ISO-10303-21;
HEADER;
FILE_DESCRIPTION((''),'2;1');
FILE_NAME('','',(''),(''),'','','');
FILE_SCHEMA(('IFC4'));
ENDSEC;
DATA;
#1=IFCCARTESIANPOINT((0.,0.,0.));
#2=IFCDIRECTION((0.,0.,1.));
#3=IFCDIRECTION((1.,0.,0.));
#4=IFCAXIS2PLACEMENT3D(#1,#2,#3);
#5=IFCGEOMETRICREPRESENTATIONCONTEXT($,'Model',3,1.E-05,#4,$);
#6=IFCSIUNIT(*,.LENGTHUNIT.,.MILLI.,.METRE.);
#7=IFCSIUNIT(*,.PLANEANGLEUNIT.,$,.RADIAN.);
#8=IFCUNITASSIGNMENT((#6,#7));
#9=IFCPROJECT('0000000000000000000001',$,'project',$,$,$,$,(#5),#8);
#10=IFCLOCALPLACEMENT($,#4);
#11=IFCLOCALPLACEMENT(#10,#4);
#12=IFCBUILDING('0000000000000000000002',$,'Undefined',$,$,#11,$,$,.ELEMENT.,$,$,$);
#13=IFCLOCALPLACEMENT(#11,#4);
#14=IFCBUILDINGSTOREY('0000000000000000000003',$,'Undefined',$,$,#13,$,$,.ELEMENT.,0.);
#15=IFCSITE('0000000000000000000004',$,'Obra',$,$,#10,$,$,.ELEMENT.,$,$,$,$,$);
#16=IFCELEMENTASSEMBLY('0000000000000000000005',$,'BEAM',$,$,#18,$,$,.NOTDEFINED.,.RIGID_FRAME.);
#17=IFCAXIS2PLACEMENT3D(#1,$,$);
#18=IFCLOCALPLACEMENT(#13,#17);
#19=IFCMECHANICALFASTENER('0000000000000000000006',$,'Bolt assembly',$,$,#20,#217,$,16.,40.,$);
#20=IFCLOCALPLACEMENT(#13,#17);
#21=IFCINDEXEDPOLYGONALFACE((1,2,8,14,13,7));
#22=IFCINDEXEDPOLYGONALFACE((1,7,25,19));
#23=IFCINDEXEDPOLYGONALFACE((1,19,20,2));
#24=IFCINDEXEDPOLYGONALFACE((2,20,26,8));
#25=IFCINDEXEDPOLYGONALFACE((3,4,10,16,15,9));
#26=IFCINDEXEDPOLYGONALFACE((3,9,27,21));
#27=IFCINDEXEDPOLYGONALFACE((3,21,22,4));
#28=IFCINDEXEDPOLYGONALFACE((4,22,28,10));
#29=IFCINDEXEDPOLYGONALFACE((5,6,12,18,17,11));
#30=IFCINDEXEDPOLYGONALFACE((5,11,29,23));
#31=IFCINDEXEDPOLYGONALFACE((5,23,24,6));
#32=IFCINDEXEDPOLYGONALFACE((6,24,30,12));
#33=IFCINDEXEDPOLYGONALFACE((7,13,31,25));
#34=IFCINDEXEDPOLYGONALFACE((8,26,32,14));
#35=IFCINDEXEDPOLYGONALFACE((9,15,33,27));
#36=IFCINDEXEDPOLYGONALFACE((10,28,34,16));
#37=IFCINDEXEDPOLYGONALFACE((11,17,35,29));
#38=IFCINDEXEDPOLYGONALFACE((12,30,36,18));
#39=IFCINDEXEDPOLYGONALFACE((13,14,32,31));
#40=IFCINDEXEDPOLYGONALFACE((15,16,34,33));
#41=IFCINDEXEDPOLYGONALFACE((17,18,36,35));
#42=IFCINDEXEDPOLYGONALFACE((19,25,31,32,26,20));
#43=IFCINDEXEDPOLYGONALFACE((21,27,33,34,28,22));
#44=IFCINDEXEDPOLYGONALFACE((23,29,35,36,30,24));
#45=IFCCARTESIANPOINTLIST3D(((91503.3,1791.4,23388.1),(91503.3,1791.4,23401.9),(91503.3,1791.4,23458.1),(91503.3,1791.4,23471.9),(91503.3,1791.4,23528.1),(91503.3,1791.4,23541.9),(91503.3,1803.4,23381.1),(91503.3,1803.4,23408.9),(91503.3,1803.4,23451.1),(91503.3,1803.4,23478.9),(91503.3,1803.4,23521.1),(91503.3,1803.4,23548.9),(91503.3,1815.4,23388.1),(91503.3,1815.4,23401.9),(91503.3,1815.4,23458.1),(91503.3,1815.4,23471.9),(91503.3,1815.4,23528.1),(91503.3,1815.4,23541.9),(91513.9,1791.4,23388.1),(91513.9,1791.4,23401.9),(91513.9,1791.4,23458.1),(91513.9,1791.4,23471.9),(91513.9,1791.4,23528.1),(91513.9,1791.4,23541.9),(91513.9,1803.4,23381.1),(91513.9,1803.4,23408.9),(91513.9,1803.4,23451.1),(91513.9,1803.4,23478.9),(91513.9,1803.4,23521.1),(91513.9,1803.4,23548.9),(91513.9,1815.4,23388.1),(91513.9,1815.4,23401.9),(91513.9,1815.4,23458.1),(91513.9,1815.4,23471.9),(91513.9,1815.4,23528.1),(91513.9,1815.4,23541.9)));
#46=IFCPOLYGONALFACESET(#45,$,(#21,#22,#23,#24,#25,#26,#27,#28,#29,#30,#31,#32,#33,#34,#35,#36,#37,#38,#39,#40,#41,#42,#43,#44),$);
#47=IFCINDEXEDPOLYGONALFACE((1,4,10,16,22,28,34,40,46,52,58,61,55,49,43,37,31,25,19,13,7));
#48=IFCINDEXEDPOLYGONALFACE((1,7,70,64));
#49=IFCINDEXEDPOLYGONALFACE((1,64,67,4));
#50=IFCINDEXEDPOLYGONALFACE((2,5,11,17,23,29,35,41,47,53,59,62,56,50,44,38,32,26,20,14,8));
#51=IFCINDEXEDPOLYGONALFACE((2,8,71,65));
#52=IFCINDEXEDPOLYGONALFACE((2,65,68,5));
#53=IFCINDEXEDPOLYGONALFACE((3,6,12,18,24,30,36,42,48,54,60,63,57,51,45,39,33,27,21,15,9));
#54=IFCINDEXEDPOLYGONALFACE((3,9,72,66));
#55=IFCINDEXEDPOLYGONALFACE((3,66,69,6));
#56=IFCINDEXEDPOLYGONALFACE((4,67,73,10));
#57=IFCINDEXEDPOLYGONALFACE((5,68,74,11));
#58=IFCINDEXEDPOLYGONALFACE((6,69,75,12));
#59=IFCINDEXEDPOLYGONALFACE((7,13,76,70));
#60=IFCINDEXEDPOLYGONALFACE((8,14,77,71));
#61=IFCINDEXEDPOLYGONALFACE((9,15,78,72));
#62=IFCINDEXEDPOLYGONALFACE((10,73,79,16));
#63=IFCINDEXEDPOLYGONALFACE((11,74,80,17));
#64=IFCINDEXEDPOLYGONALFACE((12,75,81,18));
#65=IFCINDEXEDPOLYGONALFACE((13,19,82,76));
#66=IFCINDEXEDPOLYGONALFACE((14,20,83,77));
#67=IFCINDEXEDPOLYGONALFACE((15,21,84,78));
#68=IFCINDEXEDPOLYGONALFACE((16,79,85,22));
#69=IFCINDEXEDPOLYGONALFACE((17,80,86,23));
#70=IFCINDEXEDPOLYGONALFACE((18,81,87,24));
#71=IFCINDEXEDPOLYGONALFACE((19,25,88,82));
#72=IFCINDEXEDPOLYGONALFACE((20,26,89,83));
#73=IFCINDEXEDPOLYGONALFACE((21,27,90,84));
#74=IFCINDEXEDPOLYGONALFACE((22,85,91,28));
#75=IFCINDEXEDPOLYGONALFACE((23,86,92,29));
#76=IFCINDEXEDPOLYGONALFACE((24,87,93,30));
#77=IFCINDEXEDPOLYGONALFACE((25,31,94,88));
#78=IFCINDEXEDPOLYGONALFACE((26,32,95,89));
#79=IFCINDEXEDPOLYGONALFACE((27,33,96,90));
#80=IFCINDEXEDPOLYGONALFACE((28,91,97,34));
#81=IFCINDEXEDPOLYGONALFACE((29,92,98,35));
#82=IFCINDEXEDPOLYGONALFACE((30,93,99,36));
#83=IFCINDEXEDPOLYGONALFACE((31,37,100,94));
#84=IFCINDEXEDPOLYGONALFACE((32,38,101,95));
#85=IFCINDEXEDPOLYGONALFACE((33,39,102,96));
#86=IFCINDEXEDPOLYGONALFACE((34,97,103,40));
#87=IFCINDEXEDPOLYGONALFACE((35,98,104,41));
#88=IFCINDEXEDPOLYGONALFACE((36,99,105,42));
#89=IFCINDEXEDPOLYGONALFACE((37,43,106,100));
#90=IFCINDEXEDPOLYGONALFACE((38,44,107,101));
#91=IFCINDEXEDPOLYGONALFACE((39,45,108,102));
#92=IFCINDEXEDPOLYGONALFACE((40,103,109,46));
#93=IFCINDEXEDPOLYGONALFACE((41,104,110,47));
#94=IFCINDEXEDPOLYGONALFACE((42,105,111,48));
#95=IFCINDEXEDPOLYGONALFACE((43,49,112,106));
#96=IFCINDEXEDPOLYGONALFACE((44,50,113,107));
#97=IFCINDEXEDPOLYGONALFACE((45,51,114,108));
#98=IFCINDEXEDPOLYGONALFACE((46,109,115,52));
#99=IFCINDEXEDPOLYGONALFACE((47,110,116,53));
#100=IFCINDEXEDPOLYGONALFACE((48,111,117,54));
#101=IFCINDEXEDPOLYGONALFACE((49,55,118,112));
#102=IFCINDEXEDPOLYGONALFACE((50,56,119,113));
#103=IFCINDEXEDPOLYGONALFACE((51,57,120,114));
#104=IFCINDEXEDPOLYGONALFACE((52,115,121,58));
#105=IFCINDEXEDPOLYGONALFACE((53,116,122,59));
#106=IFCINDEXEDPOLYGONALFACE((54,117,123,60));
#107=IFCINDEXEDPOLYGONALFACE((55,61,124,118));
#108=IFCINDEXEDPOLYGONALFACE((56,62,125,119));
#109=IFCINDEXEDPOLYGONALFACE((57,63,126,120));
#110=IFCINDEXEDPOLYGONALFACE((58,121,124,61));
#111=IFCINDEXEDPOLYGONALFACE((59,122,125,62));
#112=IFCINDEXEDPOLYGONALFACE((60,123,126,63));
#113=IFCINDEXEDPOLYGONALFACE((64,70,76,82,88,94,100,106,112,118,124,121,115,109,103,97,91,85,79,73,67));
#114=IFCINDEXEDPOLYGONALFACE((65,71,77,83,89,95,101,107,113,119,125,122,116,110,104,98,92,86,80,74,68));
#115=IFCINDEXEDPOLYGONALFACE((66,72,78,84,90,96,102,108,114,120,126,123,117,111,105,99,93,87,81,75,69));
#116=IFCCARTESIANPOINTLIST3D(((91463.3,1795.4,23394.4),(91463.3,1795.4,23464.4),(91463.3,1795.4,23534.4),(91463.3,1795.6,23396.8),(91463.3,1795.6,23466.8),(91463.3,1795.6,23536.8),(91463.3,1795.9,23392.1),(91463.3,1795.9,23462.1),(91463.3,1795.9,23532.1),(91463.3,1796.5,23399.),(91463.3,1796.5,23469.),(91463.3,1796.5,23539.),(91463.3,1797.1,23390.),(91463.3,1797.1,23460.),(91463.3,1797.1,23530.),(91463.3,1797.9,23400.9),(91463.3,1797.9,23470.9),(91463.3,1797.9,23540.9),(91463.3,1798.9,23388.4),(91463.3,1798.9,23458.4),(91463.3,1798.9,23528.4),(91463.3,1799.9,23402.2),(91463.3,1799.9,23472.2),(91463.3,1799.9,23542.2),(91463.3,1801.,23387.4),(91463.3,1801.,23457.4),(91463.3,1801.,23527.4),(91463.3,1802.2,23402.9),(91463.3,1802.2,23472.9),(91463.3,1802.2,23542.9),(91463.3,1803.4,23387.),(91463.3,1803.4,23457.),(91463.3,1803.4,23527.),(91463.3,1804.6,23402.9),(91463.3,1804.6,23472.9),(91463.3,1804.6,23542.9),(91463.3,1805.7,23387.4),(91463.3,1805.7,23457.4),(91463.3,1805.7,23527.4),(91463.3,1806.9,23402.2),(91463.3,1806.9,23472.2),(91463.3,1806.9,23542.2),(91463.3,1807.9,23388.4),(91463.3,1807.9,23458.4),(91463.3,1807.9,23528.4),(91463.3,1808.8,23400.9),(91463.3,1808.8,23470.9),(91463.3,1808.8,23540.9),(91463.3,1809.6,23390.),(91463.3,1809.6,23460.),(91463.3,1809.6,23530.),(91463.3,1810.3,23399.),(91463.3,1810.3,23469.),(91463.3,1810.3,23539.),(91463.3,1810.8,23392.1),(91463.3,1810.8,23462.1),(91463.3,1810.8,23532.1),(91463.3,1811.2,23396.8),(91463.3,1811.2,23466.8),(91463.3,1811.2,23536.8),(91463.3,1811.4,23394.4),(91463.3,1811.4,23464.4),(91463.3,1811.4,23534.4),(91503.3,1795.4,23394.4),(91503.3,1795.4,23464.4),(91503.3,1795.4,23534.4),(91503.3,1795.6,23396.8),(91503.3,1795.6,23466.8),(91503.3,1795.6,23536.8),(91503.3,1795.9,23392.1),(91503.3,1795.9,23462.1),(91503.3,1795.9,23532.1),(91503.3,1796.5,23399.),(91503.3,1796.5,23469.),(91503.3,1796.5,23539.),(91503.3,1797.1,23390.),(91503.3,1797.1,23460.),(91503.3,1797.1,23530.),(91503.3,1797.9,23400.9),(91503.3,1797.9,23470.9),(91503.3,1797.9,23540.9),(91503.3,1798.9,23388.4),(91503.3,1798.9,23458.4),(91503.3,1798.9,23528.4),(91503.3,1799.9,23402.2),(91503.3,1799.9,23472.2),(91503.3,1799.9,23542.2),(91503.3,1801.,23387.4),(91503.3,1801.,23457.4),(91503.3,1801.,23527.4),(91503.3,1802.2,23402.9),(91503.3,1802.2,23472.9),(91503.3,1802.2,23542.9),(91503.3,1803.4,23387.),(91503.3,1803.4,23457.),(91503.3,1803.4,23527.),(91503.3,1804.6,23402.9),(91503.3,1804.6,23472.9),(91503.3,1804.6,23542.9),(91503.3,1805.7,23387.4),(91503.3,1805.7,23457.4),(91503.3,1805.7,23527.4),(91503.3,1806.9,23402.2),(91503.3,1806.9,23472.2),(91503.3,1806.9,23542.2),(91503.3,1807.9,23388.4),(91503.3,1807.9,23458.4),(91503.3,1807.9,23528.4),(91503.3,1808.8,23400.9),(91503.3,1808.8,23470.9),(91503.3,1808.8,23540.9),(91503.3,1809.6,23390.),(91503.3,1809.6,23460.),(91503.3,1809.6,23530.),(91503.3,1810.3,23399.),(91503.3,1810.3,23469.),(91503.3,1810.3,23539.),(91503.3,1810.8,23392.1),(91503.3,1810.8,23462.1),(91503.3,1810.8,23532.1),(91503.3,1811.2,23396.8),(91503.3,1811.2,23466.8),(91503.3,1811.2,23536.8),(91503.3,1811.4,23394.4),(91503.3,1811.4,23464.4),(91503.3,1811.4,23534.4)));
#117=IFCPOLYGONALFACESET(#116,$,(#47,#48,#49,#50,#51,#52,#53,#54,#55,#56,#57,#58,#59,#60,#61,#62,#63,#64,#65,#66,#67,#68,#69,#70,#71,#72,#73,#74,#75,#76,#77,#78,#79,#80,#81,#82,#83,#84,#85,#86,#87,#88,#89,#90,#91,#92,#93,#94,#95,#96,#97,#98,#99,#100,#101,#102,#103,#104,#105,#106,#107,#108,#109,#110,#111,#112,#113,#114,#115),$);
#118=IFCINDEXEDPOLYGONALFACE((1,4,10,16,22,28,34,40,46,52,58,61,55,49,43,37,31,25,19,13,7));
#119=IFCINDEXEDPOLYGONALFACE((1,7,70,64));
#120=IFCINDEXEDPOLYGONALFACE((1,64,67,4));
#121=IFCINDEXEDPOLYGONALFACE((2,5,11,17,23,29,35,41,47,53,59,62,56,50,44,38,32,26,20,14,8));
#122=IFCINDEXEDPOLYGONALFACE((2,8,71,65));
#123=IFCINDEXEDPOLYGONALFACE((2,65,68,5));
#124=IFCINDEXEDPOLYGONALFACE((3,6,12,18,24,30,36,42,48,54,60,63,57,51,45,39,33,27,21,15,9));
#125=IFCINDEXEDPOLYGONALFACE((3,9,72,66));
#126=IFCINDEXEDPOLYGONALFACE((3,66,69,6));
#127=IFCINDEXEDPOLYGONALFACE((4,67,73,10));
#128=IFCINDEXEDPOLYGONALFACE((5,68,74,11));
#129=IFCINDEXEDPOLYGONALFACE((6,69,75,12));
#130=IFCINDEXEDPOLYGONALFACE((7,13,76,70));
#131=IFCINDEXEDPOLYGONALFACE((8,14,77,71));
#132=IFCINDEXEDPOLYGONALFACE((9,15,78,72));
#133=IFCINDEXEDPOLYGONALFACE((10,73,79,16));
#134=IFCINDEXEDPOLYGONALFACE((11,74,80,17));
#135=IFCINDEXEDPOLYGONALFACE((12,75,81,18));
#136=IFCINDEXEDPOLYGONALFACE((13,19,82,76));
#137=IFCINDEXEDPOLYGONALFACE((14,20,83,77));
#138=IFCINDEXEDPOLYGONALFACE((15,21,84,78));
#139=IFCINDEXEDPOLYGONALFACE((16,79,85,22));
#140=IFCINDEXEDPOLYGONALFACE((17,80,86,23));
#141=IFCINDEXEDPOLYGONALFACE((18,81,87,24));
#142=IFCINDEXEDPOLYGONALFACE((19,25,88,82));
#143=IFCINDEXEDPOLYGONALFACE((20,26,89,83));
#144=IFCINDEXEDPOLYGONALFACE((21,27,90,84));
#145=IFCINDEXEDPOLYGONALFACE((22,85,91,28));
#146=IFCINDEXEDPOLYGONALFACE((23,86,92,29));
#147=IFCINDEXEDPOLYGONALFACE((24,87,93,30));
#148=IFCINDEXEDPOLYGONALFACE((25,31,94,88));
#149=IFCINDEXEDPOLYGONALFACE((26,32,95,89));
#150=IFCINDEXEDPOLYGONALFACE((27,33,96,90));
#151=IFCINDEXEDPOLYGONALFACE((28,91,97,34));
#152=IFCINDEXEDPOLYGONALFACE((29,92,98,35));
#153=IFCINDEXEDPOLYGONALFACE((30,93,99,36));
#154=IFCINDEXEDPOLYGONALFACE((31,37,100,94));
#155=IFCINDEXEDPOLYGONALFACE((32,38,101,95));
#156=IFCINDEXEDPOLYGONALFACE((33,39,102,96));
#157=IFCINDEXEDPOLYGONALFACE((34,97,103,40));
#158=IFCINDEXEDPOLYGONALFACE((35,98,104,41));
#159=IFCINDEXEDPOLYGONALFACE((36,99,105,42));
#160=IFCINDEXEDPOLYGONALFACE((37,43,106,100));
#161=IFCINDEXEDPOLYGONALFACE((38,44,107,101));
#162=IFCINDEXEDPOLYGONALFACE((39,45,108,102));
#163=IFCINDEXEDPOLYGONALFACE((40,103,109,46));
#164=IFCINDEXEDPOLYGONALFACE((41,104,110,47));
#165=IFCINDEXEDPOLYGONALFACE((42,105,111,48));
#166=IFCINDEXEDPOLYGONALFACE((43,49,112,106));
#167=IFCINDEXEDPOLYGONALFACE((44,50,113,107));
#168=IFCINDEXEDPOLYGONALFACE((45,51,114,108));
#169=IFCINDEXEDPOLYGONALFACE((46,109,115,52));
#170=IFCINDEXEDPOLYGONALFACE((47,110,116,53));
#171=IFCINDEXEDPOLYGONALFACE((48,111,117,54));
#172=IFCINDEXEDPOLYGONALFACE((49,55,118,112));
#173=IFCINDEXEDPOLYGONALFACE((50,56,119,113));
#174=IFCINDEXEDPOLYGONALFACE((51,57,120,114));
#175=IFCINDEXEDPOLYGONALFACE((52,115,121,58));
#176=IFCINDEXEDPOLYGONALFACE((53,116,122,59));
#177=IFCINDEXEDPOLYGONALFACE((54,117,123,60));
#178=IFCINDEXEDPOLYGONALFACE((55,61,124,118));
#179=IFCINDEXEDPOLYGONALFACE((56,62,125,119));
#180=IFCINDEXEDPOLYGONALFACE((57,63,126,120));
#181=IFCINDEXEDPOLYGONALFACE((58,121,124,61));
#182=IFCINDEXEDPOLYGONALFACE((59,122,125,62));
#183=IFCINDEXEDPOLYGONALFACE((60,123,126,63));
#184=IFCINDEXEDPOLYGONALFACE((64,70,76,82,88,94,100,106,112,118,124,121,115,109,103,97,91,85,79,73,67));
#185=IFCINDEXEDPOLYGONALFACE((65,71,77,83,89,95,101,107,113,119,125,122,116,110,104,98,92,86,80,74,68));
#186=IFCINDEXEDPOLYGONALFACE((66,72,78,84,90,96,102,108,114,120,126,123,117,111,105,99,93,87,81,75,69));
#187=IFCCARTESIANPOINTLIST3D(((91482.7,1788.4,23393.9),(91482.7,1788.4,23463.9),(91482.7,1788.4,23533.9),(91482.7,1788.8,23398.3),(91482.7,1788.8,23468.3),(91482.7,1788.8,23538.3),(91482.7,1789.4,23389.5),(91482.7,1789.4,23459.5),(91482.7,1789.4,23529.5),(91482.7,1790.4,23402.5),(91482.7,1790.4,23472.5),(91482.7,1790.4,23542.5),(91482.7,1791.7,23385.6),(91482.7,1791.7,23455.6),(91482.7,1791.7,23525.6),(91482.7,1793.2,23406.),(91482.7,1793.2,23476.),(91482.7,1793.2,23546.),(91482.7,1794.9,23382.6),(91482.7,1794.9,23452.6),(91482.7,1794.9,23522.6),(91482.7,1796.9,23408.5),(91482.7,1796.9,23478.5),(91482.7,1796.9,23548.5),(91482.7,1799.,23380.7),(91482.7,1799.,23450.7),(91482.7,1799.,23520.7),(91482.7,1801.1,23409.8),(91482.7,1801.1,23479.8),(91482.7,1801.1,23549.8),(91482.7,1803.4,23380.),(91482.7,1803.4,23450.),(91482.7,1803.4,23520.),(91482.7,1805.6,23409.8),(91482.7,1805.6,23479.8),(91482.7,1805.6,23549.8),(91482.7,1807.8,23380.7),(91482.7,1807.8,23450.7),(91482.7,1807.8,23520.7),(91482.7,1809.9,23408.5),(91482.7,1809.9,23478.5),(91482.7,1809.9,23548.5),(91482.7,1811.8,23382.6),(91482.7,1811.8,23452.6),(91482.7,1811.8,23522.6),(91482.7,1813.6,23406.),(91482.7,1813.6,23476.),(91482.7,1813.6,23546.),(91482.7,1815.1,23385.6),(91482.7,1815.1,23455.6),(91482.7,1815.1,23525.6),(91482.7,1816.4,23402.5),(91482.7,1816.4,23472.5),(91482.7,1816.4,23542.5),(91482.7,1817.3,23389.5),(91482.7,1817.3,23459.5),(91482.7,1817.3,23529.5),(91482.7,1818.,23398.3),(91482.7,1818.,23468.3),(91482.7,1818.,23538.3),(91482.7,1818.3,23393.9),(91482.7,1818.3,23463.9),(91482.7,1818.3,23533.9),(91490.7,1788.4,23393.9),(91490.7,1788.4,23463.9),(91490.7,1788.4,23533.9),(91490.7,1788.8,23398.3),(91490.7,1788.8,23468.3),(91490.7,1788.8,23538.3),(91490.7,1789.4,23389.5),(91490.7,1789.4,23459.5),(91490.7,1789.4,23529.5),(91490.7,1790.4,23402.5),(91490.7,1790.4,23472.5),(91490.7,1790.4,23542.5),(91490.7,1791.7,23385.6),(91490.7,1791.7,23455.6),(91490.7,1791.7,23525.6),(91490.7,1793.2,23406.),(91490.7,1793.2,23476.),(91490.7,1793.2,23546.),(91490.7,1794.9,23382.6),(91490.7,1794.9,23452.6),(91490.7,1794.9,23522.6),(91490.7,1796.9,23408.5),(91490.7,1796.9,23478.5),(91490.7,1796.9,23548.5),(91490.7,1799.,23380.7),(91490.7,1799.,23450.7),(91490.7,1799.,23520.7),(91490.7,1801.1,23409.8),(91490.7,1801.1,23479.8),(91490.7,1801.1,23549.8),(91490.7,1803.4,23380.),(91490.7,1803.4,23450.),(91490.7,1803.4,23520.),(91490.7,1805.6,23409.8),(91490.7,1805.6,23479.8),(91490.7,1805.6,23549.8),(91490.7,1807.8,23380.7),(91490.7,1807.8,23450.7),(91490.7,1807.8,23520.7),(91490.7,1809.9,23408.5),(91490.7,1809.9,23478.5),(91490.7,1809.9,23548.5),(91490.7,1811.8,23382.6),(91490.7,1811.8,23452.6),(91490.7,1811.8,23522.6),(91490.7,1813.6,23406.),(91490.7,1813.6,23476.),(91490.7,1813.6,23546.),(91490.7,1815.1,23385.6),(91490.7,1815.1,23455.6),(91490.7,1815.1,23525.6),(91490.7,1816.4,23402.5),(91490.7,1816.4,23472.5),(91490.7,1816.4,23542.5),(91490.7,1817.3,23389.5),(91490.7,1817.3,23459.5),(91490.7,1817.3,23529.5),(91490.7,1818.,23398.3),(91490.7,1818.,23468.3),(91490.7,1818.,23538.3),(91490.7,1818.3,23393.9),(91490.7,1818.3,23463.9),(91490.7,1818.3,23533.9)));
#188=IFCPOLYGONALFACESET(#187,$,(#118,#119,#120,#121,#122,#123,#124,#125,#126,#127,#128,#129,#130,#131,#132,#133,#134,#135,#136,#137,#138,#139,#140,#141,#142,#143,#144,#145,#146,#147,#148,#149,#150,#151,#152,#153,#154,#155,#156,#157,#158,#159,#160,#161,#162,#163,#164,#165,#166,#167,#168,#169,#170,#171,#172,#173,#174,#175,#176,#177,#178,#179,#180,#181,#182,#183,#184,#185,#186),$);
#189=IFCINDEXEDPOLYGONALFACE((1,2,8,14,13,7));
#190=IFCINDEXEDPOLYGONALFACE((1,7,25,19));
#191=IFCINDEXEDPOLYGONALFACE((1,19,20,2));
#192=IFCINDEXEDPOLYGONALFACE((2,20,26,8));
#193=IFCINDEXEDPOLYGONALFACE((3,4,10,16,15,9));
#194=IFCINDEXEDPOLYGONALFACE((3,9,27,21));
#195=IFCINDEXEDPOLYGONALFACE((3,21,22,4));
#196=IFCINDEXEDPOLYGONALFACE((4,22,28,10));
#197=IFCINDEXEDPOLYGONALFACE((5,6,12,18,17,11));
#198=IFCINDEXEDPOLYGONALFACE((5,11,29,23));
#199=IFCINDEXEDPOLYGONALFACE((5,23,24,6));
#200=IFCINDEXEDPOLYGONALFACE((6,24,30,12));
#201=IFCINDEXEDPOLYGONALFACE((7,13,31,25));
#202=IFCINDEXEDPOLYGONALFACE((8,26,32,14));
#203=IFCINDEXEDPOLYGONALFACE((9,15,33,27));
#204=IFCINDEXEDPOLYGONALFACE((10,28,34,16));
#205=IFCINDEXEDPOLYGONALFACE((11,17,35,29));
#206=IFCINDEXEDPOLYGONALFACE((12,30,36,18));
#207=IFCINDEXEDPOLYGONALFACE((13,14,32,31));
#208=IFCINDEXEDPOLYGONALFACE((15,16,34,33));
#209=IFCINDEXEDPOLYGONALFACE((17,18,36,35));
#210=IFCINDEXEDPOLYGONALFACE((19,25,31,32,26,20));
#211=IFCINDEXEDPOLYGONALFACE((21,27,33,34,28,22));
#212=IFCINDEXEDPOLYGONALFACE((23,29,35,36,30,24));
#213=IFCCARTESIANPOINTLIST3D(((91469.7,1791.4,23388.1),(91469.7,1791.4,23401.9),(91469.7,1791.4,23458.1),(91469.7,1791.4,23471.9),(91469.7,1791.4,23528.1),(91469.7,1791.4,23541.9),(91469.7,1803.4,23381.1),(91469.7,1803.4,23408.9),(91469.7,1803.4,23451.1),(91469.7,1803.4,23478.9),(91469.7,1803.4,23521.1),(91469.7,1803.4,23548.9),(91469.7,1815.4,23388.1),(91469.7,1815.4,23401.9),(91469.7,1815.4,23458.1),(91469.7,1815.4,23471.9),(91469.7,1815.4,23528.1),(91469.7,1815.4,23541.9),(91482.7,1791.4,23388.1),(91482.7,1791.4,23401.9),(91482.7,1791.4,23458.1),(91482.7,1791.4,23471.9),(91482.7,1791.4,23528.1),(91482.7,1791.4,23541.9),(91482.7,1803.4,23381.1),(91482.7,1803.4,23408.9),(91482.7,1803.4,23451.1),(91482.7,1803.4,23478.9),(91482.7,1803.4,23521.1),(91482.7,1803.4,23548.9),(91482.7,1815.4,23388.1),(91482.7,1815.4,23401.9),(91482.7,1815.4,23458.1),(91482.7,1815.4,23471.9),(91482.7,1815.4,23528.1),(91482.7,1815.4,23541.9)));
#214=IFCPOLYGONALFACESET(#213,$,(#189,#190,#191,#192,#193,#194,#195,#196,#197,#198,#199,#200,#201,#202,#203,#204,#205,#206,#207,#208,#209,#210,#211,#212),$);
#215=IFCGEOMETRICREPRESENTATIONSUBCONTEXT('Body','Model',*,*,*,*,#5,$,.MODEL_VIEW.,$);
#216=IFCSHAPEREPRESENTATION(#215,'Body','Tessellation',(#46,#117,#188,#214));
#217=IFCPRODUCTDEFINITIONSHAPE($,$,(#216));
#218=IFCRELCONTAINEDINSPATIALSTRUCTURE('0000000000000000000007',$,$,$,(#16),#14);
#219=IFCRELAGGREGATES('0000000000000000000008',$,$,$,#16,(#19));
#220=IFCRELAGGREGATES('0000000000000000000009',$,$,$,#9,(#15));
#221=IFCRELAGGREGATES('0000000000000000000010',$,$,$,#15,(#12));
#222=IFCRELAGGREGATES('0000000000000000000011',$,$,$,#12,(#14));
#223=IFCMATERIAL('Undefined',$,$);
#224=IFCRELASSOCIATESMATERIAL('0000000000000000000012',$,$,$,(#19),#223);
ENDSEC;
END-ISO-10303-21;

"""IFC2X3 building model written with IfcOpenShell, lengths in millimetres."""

from ifc_helpers import new_model, si_unit, frame, origin_with_axes, origin_2d_with_axis, place, context, subcontext, project, spatial, polyline, circle, outline, extrude, source, transform, mapped, material, element, aggregate, save


model = new_model("IFC2X3")

# Units and contexts
model_context = context("Model", 3, precision=1e-05, world=origin_with_axes())
body_context = subcontext(model_context, "Body", "Model", "MODEL_VIEW")
ifc_project = project(units=[si_unit("LENGTHUNIT", "METRE", prefix="MILLI"), si_unit("PLANEANGLEUNIT", "RADIAN")], contexts=[model_context])

# Site, building, storey
site_placement = place(None, origin_with_axes())
site = spatial("IfcSite", under=ifc_project, at=site_placement, Name="Obra", CompositionType="ELEMENT")
building_placement = place(site_placement, origin_with_axes())
building = spatial("IfcBuilding", under=site, at=building_placement, Name="Undefined", CompositionType="ELEMENT")
storey_placement = place(building_placement, origin_with_axes())
storey = spatial("IfcBuildingStorey", under=building, at=storey_placement, Name="Undefined", CompositionType="ELEMENT", Elevation=0.0)

# Element assembly
assembly_1_placement = place(storey_placement, origin_with_axes())
assembly_1 = element("IfcElementAssembly", 1, at=assembly_1_placement, inside=storey, Name="BEAM", AssemblyPlace="NOTDEFINED", PredefinedType="RIGID_FRAME")

# Mechanical fastener
ifc_material_1 = material(Name="Undefined")
shared_shape_1 = source(origin_with_axes(), body_context, "Body", "SweptSolid", [
    extrude(outline(polyline([(13.9, 0.0), (6.9, 12.0), (-6.9, 12.0), (-13.9, 0.0), (-6.9, -12.0), (6.9, -12.0), (13.9, 0.0)])), frame((0.0, -13.9, 0.0), z_axis=(0.0, 1.0, 0.0), x_axis=(1.0, 0.0, 0.0)), (0.0, 0.0, 1.0), 10.6),
    extrude(circle(Radius=8.0, at=origin_2d_with_axis()), frame((0.0, -3.3, 0.0), z_axis=(0.0, 1.0, 0.0), x_axis=(1.0, 0.0, 0.0)), (0.0, 0.0, 1.0), 40.0),
    extrude(circle(Radius=15.0, at=origin_2d_with_axis()), frame((0.0, 9.3, 0.0), z_axis=(0.0, 1.0, 0.0), x_axis=(1.0, 0.0, 0.0)), (0.0, 0.0, 1.0), 8.0),
    extrude(outline(polyline([(13.9, 0.0), (6.9, 12.0), (-6.9, 12.0), (-13.9, 0.0), (-6.9, -12.0), (6.9, -12.0), (13.9, 0.0)])), frame((0.0, 17.3, 0.0), z_axis=(0.0, 1.0, 0.0), x_axis=(1.0, 0.0, 0.0)), (0.0, 0.0, 1.0), 13.0),
])
mechanical_fastener_1_placement = place(assembly_1_placement, frame((91500.0, 1763.4, 23570.0), z_axis=(0.0, 1.0, 0.0), x_axis=(0.0, 0.0, -1.0)))
mechanical_fastener_1 = element("IfcMechanicalFastener", 2, at=mechanical_fastener_1_placement, material=ifc_material_1, Name="Bolt assembly", NominalDiameter=16.0, NominalLength=40.0, context=body_context, shape_type="MappedRepresentation", body=[
    mapped(shared_shape_1, transform((35.0, 0.0, 40.0))),
    mapped(shared_shape_1, transform((105.0, 0.0, 40.0))),
    mapped(shared_shape_1, transform((175.0, 0.0, 40.0))),
])
aggregate(assembly_1, [mechanical_fastener_1])

save(model, "model.ifc")
